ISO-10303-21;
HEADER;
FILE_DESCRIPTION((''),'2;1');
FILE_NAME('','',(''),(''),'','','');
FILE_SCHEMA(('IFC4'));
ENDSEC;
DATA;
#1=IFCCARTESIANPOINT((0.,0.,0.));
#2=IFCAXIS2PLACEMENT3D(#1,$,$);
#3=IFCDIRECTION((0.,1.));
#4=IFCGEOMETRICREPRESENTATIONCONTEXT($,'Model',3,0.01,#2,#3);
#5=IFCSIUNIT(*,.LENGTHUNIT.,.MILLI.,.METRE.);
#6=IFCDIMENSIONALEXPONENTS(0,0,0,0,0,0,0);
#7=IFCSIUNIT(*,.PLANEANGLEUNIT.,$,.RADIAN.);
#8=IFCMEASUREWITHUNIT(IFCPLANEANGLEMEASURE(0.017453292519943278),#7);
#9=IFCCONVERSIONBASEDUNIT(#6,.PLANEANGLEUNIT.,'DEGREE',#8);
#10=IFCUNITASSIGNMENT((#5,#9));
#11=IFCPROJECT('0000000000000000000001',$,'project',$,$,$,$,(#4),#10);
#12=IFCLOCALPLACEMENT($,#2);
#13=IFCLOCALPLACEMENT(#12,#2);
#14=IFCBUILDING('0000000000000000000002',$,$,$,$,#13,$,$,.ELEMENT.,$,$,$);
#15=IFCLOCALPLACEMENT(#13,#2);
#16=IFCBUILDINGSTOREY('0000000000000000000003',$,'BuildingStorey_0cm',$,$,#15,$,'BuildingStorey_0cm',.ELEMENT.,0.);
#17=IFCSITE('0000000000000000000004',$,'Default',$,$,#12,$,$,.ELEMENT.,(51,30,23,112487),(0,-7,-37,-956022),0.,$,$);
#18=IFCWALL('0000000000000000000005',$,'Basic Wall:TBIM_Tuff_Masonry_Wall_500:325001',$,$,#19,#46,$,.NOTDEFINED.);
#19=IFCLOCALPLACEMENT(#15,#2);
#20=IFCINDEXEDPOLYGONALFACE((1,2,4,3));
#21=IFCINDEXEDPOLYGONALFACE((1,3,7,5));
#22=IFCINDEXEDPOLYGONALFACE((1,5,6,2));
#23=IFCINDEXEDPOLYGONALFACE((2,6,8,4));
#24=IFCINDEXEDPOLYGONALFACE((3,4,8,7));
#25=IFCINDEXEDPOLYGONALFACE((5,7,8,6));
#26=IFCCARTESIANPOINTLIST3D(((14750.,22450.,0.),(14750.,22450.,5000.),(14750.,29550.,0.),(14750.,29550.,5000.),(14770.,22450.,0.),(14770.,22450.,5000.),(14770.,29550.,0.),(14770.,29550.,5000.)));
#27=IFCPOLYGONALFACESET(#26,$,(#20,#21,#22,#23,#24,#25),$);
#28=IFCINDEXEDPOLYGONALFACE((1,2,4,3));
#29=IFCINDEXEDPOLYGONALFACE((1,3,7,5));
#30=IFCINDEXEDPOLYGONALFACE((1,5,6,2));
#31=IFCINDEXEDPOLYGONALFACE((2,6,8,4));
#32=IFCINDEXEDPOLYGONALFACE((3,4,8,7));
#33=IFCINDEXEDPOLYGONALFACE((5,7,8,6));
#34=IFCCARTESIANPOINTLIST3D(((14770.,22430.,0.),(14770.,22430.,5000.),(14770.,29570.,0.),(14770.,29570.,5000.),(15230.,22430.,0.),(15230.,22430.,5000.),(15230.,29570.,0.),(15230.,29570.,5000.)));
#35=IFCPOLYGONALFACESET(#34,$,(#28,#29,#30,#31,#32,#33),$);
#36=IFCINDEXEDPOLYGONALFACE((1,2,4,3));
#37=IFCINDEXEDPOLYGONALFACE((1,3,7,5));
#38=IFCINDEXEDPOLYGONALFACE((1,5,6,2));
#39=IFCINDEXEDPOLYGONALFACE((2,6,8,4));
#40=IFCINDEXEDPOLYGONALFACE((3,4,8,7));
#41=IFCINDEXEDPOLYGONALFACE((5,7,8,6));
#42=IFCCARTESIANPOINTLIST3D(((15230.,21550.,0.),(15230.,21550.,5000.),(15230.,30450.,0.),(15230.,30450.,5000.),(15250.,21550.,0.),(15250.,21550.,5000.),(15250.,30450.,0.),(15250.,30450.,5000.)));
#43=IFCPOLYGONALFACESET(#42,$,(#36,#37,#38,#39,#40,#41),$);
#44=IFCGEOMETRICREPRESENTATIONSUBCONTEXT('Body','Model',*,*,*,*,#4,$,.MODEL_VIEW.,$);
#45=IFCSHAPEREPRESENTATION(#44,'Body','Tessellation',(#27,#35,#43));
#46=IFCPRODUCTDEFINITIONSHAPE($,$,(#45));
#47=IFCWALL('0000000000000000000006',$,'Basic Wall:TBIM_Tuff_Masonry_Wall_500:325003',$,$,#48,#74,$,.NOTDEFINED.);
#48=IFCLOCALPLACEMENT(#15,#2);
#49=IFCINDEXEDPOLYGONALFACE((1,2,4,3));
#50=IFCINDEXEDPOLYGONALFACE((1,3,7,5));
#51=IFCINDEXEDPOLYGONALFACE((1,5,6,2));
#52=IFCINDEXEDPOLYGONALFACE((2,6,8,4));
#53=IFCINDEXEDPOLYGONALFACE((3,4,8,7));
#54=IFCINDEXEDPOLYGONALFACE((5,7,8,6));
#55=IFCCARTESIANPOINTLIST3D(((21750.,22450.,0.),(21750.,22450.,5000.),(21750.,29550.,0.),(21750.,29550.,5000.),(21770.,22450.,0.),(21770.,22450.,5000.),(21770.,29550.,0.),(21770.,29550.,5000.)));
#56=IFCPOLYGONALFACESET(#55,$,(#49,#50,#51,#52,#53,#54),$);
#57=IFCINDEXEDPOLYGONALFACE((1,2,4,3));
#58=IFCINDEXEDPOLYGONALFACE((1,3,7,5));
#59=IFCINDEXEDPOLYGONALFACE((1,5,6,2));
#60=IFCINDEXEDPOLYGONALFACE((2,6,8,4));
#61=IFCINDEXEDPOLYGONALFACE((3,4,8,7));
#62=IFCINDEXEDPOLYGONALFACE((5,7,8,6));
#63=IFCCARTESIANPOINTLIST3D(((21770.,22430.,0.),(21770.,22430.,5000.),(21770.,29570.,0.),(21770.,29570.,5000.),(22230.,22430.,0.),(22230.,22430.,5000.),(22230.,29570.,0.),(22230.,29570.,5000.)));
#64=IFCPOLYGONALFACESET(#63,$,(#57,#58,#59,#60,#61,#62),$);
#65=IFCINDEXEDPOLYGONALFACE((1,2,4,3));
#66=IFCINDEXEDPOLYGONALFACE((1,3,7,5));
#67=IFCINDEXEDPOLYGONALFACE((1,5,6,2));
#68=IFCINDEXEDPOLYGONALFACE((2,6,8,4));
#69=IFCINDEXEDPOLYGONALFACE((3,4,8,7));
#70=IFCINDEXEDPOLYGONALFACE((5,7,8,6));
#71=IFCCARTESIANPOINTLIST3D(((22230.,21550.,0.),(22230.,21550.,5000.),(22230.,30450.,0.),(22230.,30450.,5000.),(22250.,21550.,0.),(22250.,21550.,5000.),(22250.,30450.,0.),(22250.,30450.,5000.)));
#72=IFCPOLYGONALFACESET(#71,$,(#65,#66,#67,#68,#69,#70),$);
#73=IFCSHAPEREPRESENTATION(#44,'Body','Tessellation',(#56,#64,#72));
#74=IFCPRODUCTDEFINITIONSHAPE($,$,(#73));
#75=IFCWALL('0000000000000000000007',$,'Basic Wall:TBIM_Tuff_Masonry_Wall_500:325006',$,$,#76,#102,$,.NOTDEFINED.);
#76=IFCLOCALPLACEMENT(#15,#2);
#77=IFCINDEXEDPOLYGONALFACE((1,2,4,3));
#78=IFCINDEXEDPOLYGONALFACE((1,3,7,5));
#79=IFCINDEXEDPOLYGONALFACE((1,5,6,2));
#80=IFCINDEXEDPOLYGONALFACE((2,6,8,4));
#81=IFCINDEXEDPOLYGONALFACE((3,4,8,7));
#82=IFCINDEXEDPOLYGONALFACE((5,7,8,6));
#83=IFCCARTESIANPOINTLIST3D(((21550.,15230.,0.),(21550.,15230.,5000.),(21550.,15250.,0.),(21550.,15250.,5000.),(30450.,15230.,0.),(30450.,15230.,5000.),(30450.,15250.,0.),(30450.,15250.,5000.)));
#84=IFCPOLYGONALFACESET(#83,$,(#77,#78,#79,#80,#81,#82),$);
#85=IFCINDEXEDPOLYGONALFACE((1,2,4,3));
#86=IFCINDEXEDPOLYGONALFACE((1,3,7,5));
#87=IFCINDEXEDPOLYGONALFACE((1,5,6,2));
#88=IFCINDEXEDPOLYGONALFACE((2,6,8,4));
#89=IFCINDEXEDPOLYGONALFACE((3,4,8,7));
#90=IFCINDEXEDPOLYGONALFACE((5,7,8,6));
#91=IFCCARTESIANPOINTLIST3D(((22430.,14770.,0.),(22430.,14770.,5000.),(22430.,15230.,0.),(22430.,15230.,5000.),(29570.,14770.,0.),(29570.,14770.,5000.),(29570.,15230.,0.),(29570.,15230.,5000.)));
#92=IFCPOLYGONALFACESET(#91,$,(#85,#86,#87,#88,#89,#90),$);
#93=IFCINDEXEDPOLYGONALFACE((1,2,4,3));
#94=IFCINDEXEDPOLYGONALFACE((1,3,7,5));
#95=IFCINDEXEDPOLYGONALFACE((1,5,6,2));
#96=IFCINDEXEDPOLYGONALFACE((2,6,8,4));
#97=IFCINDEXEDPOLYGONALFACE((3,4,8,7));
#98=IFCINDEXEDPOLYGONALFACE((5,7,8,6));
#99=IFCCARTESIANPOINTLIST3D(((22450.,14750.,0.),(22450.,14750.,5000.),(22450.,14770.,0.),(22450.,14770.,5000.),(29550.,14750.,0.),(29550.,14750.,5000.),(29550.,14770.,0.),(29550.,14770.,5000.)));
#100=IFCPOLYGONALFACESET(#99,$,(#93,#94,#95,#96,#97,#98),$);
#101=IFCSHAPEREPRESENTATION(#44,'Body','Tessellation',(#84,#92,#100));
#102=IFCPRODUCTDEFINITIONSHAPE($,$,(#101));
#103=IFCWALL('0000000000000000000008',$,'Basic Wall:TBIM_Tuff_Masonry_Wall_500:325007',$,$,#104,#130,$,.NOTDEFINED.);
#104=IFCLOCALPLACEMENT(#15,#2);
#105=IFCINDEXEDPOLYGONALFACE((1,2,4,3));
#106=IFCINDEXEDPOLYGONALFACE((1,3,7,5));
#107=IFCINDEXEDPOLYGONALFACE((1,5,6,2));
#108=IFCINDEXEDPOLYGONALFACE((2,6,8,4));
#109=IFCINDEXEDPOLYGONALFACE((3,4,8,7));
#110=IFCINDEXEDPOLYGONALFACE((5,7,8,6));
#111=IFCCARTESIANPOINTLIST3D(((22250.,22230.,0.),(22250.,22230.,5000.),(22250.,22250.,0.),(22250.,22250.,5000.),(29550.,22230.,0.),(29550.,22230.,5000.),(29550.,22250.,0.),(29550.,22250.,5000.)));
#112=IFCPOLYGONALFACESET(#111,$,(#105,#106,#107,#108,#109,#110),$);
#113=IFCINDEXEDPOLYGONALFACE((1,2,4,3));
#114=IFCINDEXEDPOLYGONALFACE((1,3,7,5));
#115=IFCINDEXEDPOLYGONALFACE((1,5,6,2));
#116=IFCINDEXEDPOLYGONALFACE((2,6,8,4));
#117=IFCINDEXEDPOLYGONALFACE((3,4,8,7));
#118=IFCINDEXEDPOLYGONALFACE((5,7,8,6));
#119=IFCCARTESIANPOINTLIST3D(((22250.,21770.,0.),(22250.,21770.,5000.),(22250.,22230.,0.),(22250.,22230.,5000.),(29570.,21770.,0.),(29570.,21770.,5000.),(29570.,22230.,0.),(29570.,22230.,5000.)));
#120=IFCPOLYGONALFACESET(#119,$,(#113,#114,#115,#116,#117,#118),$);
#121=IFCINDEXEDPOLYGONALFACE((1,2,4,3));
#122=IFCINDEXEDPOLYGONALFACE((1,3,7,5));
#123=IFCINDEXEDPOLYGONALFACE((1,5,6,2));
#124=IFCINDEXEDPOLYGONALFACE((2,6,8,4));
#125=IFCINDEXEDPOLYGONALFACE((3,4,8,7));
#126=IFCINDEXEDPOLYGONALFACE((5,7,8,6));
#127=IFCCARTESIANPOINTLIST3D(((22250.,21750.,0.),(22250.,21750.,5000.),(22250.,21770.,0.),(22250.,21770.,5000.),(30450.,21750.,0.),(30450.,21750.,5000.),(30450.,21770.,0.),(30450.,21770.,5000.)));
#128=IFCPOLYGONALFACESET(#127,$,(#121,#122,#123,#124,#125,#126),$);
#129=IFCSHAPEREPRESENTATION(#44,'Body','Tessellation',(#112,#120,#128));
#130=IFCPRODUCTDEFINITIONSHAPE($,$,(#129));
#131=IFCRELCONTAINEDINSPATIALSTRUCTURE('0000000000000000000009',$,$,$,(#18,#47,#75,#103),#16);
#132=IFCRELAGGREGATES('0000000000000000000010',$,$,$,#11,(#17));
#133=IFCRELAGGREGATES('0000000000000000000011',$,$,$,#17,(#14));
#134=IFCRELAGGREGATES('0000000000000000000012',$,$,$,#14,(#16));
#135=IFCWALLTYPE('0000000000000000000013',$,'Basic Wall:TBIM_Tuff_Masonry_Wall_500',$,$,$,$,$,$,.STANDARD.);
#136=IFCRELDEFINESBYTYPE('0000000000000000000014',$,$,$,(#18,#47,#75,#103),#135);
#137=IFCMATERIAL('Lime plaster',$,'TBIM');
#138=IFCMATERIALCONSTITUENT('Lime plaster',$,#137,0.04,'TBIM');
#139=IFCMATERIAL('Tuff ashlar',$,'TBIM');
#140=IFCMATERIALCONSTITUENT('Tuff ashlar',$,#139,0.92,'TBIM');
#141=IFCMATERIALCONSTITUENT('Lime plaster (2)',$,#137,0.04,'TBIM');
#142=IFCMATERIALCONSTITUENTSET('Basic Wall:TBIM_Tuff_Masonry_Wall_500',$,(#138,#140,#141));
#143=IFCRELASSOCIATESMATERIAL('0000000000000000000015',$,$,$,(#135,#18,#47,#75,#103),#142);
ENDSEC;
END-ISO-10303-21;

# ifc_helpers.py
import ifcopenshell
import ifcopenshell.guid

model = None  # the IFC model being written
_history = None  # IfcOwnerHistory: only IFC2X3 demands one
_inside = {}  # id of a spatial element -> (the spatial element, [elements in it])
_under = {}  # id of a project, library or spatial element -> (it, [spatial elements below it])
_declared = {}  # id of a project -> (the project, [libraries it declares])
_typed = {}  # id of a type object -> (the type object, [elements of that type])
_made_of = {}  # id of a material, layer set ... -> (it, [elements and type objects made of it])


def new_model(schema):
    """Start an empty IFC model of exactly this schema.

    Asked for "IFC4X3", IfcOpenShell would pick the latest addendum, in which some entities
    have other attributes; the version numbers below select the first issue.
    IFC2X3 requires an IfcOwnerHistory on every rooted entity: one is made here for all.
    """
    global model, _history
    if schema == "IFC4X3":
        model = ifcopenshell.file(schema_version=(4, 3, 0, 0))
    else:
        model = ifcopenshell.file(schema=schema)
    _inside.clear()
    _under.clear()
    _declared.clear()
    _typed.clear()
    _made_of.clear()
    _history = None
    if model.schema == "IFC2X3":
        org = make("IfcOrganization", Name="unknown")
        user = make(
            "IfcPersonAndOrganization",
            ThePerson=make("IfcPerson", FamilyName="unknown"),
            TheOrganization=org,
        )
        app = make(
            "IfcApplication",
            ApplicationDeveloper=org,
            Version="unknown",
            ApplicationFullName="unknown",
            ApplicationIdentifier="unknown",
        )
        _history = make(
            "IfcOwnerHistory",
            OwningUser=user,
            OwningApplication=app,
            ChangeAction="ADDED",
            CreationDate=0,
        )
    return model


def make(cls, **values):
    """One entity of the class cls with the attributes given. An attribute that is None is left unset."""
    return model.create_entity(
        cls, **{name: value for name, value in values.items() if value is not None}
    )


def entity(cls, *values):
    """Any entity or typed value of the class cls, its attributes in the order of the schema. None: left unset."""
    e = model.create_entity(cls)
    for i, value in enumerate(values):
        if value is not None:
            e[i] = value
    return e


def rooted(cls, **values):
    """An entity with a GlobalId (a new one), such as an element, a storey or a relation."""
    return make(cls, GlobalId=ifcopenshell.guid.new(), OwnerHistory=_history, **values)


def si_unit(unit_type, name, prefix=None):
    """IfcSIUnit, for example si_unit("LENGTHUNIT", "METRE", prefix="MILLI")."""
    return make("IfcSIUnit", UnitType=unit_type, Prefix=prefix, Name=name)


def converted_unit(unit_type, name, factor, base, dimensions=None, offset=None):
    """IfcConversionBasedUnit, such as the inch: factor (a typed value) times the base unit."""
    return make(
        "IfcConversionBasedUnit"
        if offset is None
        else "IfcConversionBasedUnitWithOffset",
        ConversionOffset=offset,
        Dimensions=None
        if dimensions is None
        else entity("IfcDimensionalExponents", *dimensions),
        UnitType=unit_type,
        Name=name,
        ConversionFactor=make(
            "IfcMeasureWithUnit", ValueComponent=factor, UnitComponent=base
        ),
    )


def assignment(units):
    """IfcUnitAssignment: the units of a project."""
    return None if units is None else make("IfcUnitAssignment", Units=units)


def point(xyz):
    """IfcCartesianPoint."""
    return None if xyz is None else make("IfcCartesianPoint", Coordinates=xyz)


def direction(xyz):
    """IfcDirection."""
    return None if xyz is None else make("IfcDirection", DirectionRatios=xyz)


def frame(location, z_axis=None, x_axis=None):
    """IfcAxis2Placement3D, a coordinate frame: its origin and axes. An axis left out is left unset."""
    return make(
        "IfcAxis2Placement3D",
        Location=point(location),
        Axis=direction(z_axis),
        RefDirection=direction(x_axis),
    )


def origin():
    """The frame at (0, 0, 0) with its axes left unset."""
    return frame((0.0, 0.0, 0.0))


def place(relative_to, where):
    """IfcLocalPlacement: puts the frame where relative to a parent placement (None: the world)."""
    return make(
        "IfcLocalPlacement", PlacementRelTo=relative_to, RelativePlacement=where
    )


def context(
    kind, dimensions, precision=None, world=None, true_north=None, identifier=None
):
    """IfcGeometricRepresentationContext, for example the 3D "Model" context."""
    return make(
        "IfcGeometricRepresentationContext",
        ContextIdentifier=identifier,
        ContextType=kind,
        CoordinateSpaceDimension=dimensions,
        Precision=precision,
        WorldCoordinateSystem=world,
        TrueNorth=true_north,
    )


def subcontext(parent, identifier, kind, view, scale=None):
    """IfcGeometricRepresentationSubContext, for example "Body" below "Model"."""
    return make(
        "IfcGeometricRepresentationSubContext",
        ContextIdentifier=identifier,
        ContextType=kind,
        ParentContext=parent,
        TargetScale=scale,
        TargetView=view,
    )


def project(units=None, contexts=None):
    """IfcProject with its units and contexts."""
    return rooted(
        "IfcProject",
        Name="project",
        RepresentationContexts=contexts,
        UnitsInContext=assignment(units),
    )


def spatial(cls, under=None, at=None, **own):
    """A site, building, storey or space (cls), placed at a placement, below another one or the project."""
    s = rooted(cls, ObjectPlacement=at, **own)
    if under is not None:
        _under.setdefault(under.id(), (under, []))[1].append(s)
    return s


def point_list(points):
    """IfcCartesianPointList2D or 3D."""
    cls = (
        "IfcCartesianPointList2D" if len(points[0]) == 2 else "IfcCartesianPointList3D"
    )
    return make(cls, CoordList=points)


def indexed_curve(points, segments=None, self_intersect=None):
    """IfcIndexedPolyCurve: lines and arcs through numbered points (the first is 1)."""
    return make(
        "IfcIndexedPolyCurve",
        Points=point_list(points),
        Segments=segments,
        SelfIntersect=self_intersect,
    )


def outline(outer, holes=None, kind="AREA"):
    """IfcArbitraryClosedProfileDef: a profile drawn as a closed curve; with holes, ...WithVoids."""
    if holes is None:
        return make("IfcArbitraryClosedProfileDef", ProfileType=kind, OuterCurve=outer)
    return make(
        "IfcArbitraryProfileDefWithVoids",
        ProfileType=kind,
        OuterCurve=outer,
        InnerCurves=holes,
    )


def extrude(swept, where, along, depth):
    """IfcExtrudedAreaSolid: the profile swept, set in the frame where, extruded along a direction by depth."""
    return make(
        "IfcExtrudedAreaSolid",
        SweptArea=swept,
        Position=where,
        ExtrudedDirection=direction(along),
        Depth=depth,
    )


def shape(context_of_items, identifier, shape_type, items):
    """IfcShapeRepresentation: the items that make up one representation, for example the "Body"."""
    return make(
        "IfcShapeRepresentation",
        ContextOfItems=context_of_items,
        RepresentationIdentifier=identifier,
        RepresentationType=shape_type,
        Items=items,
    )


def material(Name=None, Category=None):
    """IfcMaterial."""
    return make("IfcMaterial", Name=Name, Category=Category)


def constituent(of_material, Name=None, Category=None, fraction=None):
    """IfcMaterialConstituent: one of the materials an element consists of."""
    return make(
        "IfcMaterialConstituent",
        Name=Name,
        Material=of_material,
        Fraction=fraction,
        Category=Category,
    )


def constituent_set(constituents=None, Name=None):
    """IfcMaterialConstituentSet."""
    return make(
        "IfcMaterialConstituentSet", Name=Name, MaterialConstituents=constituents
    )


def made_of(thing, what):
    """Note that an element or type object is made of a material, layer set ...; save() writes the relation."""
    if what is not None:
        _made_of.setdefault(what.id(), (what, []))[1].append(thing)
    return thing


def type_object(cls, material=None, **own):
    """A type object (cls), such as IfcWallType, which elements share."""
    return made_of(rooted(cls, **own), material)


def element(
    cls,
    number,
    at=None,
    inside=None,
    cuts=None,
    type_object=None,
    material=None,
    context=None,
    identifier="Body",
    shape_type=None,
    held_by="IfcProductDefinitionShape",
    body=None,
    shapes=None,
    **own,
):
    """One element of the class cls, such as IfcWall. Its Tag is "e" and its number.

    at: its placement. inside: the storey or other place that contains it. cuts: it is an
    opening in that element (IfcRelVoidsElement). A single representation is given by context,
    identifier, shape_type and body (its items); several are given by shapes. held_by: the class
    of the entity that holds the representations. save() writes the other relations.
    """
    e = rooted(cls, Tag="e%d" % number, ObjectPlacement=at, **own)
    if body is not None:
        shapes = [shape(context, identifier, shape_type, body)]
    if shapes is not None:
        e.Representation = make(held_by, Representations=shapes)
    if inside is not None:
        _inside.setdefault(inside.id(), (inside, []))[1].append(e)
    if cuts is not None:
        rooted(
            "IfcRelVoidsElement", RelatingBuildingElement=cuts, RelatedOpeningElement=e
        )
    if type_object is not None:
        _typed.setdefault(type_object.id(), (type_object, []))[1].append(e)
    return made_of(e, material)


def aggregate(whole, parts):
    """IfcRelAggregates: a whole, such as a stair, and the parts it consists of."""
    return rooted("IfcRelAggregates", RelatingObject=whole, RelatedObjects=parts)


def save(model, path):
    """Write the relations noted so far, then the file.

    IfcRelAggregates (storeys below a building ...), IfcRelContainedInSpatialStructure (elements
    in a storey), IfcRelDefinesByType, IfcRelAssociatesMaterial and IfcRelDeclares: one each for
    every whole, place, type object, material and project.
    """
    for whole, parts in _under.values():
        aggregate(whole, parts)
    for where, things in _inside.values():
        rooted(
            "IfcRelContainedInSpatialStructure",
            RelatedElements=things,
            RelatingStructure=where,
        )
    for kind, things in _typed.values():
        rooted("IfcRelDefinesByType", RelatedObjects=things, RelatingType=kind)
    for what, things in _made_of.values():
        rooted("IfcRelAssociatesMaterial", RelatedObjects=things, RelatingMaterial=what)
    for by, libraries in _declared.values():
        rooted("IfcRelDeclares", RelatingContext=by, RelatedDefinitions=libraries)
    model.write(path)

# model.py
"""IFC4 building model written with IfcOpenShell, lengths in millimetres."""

from ifc_helpers import new_model, entity, si_unit, converted_unit, direction, frame, origin, place, context, subcontext, project, spatial, indexed_curve, outline, extrude, material, constituent, constituent_set, type_object, element, save


model = new_model("IFC4")

# Units and contexts
model_context = context("Model", 3, precision=0.01, world=origin(), true_north=direction((0.0, 1.0)))
body_context = subcontext(model_context, "Body", "Model", "MODEL_VIEW")
ifc_project = project(units=[si_unit("LENGTHUNIT", "METRE", prefix="MILLI"), converted_unit("PLANEANGLEUNIT", "DEGREE", entity("IfcPlaneAngleMeasure", 0.017453292519943278), si_unit("PLANEANGLEUNIT", "RADIAN"), dimensions=[0, 0, 0, 0, 0, 0, 0])], contexts=[model_context])

# Site, building, storey
site_placement = place(None, origin())
site = spatial("IfcSite", under=ifc_project, at=site_placement, Name="Default", CompositionType="ELEMENT", RefLatitude=(51, 30, 23, 112487), RefLongitude=(0, -7, -37, -956022), RefElevation=0.0)
building_placement = place(site_placement, origin())
building = spatial("IfcBuilding", under=site, at=building_placement, CompositionType="ELEMENT")
storey_placement = place(building_placement, origin())
storey = spatial("IfcBuildingStorey", under=building, at=storey_placement, Name="BuildingStorey_0cm", LongName="BuildingStorey_0cm", CompositionType="ELEMENT", Elevation=0.0)

# Shared definitions
ifc_material_1 = material(Name="Tuff ashlar", Category="TBIM")
ifc_material_2 = material(Name="Lime plaster", Category="TBIM")

# Shared definitions
ifc_constituent_1 = constituent(ifc_material_2, Name="Lime plaster", Category="TBIM", fraction=0.04)
ifc_constituent_2 = constituent(ifc_material_1, Name="Tuff ashlar", Category="TBIM", fraction=0.92)
ifc_constituent_3 = constituent(ifc_material_2, Name="Lime plaster (2)", Category="TBIM", fraction=0.04)
ifc_constituent_set_1 = constituent_set(constituents=[ifc_constituent_1, ifc_constituent_2, ifc_constituent_3], Name="Basic Wall:TBIM_Tuff_Masonry_Wall_500")
wall_type_1 = type_object("IfcWallType", Name="Basic Wall:TBIM_Tuff_Masonry_Wall_500", PredefinedType="STANDARD", material=ifc_constituent_set_1)

# Wall
wall_1_placement = place(storey_placement, frame((15000.0, 22450.0, 0.0), z_axis=(0.0, 0.0, 1.0), x_axis=(0.0, 1.0, 0.0)))
element("IfcWall", 1, at=wall_1_placement, inside=storey, type_object=wall_type_1, material=ifc_constituent_set_1, Name="Basic Wall:TBIM_Tuff_Masonry_Wall_500:325001", PredefinedType="NOTDEFINED", context=body_context, shape_type="SweptSolid", body=[
    extrude(outline(indexed_curve([(-10.0, -3550.0), (10.0, -3550.0), (10.0, 3550.0), (-10.0, 3550.0), (-10.0, -3550.0)], self_intersect=False)), frame((3550.0, 240.0, 0.0), z_axis=(0.0, 0.0, 1.0), x_axis=(0.0, -1.0, 0.0)), (0.0, 0.0, 1.0), 5000.0),
    extrude(outline(indexed_curve([(-3570.0, -230.0), (3570.0, -230.0), (3570.0, 230.0), (-3570.0, 230.0), (-3570.0, -230.0)], self_intersect=False)), frame((3550.0, 0.0, 0.0)), (0.0, 0.0, 1.0), 5000.0),
    extrude(outline(indexed_curve([(-10.0, -4450.0), (10.0, -4450.0), (10.0, 4450.0), (-10.0, 4450.0), (-10.0, -4450.0)], self_intersect=False)), frame((3550.0, -240.0, 0.0), z_axis=(0.0, 0.0, 1.0), x_axis=(0.0, 1.0, 0.0)), (0.0, 0.0, 1.0), 5000.0),
])

# Walls
wall_2_placement = place(storey_placement, frame((22000.0, 22450.0, 0.0), z_axis=(0.0, 0.0, 1.0), x_axis=(0.0, 1.0, 0.0)))
element("IfcWall", 2, at=wall_2_placement, inside=storey, type_object=wall_type_1, material=ifc_constituent_set_1, Name="Basic Wall:TBIM_Tuff_Masonry_Wall_500:325003", PredefinedType="NOTDEFINED", context=body_context, shape_type="SweptSolid", body=[
    extrude(outline(indexed_curve([(-10.0, -3550.0), (10.0, -3550.0), (10.0, 3550.0), (-10.0, 3550.0), (-10.0, -3550.0)], self_intersect=False)), frame((3550.0, 240.0, 0.0), z_axis=(0.0, 0.0, 1.0), x_axis=(0.0, -1.0, 0.0)), (0.0, 0.0, 1.0), 5000.0),
    extrude(outline(indexed_curve([(-3570.0, -230.0), (3570.0, -230.0), (3570.0, 230.0), (-3570.0, 230.0), (-3570.0, -230.0)], self_intersect=False)), frame((3550.0, 0.0, 0.0)), (0.0, 0.0, 1.0), 5000.0),
    extrude(outline(indexed_curve([(-10.0, -4450.0), (10.0, -4450.0), (10.0, 4450.0), (-10.0, 4450.0), (-10.0, -4450.0)], self_intersect=False)), frame((3550.0, -240.0, 0.0), z_axis=(0.0, 0.0, 1.0), x_axis=(0.0, 1.0, 0.0)), (0.0, 0.0, 1.0), 5000.0),
])
wall_3_placement = place(storey_placement, frame((22450.0, 15000.0, 0.0)))
element("IfcWall", 3, at=wall_3_placement, inside=storey, type_object=wall_type_1, material=ifc_constituent_set_1, Name="Basic Wall:TBIM_Tuff_Masonry_Wall_500:325006", PredefinedType="NOTDEFINED", context=body_context, shape_type="SweptSolid", body=[
    extrude(outline(indexed_curve([(-10.0, -4450.0), (10.0, -4450.0), (10.0, 4450.0), (-10.0, 4450.0), (-10.0, -4450.0)], self_intersect=False)), frame((3550.0, 240.0, 0.0), z_axis=(0.0, 0.0, 1.0), x_axis=(0.0, -1.0, 0.0)), (0.0, 0.0, 1.0), 5000.0),
    extrude(outline(indexed_curve([(-3570.0, -230.0), (3570.0, -230.0), (3570.0, 230.0), (-3570.0, 230.0), (-3570.0, -230.0)], self_intersect=False)), frame((3550.0, 0.0, 0.0)), (0.0, 0.0, 1.0), 5000.0),
    extrude(outline(indexed_curve([(-10.0, -3550.0), (10.0, -3550.0), (10.0, 3550.0), (-10.0, 3550.0), (-10.0, -3550.0)], self_intersect=False)), frame((3550.0, -240.0, 0.0), z_axis=(0.0, 0.0, 1.0), x_axis=(0.0, 1.0, 0.0)), (0.0, 0.0, 1.0), 5000.0),
])
wall_4_placement = place(storey_placement, frame((22250.0, 22000.0, 0.0)))
element("IfcWall", 4, at=wall_4_placement, inside=storey, type_object=wall_type_1, material=ifc_constituent_set_1, Name="Basic Wall:TBIM_Tuff_Masonry_Wall_500:325007", PredefinedType="NOTDEFINED", context=body_context, shape_type="SweptSolid", body=[
    extrude(outline(indexed_curve([(-10.0, -3650.0), (10.0, -3650.0), (10.0, 3650.0), (-10.0, 3650.0), (-10.0, -3650.0)], self_intersect=False)), frame((3650.0, 240.0, 0.0), z_axis=(0.0, 0.0, 1.0), x_axis=(0.0, -1.0, 0.0)), (0.0, 0.0, 1.0), 5000.0),
    extrude(outline(indexed_curve([(-3660.0, -230.0), (3660.0, -230.0), (3660.0, 230.0), (-3660.0, 230.0), (-3660.0, -230.0)], self_intersect=False)), frame((3660.0, 0.0, 0.0)), (0.0, 0.0, 1.0), 5000.0),
    extrude(outline(indexed_curve([(-10.0, -4100.0), (10.0, -4100.0), (10.0, 4100.0), (-10.0, 4100.0), (-10.0, -4100.0)], self_intersect=False)), frame((4100.0, -240.0, 0.0), z_axis=(0.0, 0.0, 1.0), x_axis=(0.0, 1.0, 0.0)), (0.0, 0.0, 1.0), 5000.0),
])

save(model, "model.ifc")
